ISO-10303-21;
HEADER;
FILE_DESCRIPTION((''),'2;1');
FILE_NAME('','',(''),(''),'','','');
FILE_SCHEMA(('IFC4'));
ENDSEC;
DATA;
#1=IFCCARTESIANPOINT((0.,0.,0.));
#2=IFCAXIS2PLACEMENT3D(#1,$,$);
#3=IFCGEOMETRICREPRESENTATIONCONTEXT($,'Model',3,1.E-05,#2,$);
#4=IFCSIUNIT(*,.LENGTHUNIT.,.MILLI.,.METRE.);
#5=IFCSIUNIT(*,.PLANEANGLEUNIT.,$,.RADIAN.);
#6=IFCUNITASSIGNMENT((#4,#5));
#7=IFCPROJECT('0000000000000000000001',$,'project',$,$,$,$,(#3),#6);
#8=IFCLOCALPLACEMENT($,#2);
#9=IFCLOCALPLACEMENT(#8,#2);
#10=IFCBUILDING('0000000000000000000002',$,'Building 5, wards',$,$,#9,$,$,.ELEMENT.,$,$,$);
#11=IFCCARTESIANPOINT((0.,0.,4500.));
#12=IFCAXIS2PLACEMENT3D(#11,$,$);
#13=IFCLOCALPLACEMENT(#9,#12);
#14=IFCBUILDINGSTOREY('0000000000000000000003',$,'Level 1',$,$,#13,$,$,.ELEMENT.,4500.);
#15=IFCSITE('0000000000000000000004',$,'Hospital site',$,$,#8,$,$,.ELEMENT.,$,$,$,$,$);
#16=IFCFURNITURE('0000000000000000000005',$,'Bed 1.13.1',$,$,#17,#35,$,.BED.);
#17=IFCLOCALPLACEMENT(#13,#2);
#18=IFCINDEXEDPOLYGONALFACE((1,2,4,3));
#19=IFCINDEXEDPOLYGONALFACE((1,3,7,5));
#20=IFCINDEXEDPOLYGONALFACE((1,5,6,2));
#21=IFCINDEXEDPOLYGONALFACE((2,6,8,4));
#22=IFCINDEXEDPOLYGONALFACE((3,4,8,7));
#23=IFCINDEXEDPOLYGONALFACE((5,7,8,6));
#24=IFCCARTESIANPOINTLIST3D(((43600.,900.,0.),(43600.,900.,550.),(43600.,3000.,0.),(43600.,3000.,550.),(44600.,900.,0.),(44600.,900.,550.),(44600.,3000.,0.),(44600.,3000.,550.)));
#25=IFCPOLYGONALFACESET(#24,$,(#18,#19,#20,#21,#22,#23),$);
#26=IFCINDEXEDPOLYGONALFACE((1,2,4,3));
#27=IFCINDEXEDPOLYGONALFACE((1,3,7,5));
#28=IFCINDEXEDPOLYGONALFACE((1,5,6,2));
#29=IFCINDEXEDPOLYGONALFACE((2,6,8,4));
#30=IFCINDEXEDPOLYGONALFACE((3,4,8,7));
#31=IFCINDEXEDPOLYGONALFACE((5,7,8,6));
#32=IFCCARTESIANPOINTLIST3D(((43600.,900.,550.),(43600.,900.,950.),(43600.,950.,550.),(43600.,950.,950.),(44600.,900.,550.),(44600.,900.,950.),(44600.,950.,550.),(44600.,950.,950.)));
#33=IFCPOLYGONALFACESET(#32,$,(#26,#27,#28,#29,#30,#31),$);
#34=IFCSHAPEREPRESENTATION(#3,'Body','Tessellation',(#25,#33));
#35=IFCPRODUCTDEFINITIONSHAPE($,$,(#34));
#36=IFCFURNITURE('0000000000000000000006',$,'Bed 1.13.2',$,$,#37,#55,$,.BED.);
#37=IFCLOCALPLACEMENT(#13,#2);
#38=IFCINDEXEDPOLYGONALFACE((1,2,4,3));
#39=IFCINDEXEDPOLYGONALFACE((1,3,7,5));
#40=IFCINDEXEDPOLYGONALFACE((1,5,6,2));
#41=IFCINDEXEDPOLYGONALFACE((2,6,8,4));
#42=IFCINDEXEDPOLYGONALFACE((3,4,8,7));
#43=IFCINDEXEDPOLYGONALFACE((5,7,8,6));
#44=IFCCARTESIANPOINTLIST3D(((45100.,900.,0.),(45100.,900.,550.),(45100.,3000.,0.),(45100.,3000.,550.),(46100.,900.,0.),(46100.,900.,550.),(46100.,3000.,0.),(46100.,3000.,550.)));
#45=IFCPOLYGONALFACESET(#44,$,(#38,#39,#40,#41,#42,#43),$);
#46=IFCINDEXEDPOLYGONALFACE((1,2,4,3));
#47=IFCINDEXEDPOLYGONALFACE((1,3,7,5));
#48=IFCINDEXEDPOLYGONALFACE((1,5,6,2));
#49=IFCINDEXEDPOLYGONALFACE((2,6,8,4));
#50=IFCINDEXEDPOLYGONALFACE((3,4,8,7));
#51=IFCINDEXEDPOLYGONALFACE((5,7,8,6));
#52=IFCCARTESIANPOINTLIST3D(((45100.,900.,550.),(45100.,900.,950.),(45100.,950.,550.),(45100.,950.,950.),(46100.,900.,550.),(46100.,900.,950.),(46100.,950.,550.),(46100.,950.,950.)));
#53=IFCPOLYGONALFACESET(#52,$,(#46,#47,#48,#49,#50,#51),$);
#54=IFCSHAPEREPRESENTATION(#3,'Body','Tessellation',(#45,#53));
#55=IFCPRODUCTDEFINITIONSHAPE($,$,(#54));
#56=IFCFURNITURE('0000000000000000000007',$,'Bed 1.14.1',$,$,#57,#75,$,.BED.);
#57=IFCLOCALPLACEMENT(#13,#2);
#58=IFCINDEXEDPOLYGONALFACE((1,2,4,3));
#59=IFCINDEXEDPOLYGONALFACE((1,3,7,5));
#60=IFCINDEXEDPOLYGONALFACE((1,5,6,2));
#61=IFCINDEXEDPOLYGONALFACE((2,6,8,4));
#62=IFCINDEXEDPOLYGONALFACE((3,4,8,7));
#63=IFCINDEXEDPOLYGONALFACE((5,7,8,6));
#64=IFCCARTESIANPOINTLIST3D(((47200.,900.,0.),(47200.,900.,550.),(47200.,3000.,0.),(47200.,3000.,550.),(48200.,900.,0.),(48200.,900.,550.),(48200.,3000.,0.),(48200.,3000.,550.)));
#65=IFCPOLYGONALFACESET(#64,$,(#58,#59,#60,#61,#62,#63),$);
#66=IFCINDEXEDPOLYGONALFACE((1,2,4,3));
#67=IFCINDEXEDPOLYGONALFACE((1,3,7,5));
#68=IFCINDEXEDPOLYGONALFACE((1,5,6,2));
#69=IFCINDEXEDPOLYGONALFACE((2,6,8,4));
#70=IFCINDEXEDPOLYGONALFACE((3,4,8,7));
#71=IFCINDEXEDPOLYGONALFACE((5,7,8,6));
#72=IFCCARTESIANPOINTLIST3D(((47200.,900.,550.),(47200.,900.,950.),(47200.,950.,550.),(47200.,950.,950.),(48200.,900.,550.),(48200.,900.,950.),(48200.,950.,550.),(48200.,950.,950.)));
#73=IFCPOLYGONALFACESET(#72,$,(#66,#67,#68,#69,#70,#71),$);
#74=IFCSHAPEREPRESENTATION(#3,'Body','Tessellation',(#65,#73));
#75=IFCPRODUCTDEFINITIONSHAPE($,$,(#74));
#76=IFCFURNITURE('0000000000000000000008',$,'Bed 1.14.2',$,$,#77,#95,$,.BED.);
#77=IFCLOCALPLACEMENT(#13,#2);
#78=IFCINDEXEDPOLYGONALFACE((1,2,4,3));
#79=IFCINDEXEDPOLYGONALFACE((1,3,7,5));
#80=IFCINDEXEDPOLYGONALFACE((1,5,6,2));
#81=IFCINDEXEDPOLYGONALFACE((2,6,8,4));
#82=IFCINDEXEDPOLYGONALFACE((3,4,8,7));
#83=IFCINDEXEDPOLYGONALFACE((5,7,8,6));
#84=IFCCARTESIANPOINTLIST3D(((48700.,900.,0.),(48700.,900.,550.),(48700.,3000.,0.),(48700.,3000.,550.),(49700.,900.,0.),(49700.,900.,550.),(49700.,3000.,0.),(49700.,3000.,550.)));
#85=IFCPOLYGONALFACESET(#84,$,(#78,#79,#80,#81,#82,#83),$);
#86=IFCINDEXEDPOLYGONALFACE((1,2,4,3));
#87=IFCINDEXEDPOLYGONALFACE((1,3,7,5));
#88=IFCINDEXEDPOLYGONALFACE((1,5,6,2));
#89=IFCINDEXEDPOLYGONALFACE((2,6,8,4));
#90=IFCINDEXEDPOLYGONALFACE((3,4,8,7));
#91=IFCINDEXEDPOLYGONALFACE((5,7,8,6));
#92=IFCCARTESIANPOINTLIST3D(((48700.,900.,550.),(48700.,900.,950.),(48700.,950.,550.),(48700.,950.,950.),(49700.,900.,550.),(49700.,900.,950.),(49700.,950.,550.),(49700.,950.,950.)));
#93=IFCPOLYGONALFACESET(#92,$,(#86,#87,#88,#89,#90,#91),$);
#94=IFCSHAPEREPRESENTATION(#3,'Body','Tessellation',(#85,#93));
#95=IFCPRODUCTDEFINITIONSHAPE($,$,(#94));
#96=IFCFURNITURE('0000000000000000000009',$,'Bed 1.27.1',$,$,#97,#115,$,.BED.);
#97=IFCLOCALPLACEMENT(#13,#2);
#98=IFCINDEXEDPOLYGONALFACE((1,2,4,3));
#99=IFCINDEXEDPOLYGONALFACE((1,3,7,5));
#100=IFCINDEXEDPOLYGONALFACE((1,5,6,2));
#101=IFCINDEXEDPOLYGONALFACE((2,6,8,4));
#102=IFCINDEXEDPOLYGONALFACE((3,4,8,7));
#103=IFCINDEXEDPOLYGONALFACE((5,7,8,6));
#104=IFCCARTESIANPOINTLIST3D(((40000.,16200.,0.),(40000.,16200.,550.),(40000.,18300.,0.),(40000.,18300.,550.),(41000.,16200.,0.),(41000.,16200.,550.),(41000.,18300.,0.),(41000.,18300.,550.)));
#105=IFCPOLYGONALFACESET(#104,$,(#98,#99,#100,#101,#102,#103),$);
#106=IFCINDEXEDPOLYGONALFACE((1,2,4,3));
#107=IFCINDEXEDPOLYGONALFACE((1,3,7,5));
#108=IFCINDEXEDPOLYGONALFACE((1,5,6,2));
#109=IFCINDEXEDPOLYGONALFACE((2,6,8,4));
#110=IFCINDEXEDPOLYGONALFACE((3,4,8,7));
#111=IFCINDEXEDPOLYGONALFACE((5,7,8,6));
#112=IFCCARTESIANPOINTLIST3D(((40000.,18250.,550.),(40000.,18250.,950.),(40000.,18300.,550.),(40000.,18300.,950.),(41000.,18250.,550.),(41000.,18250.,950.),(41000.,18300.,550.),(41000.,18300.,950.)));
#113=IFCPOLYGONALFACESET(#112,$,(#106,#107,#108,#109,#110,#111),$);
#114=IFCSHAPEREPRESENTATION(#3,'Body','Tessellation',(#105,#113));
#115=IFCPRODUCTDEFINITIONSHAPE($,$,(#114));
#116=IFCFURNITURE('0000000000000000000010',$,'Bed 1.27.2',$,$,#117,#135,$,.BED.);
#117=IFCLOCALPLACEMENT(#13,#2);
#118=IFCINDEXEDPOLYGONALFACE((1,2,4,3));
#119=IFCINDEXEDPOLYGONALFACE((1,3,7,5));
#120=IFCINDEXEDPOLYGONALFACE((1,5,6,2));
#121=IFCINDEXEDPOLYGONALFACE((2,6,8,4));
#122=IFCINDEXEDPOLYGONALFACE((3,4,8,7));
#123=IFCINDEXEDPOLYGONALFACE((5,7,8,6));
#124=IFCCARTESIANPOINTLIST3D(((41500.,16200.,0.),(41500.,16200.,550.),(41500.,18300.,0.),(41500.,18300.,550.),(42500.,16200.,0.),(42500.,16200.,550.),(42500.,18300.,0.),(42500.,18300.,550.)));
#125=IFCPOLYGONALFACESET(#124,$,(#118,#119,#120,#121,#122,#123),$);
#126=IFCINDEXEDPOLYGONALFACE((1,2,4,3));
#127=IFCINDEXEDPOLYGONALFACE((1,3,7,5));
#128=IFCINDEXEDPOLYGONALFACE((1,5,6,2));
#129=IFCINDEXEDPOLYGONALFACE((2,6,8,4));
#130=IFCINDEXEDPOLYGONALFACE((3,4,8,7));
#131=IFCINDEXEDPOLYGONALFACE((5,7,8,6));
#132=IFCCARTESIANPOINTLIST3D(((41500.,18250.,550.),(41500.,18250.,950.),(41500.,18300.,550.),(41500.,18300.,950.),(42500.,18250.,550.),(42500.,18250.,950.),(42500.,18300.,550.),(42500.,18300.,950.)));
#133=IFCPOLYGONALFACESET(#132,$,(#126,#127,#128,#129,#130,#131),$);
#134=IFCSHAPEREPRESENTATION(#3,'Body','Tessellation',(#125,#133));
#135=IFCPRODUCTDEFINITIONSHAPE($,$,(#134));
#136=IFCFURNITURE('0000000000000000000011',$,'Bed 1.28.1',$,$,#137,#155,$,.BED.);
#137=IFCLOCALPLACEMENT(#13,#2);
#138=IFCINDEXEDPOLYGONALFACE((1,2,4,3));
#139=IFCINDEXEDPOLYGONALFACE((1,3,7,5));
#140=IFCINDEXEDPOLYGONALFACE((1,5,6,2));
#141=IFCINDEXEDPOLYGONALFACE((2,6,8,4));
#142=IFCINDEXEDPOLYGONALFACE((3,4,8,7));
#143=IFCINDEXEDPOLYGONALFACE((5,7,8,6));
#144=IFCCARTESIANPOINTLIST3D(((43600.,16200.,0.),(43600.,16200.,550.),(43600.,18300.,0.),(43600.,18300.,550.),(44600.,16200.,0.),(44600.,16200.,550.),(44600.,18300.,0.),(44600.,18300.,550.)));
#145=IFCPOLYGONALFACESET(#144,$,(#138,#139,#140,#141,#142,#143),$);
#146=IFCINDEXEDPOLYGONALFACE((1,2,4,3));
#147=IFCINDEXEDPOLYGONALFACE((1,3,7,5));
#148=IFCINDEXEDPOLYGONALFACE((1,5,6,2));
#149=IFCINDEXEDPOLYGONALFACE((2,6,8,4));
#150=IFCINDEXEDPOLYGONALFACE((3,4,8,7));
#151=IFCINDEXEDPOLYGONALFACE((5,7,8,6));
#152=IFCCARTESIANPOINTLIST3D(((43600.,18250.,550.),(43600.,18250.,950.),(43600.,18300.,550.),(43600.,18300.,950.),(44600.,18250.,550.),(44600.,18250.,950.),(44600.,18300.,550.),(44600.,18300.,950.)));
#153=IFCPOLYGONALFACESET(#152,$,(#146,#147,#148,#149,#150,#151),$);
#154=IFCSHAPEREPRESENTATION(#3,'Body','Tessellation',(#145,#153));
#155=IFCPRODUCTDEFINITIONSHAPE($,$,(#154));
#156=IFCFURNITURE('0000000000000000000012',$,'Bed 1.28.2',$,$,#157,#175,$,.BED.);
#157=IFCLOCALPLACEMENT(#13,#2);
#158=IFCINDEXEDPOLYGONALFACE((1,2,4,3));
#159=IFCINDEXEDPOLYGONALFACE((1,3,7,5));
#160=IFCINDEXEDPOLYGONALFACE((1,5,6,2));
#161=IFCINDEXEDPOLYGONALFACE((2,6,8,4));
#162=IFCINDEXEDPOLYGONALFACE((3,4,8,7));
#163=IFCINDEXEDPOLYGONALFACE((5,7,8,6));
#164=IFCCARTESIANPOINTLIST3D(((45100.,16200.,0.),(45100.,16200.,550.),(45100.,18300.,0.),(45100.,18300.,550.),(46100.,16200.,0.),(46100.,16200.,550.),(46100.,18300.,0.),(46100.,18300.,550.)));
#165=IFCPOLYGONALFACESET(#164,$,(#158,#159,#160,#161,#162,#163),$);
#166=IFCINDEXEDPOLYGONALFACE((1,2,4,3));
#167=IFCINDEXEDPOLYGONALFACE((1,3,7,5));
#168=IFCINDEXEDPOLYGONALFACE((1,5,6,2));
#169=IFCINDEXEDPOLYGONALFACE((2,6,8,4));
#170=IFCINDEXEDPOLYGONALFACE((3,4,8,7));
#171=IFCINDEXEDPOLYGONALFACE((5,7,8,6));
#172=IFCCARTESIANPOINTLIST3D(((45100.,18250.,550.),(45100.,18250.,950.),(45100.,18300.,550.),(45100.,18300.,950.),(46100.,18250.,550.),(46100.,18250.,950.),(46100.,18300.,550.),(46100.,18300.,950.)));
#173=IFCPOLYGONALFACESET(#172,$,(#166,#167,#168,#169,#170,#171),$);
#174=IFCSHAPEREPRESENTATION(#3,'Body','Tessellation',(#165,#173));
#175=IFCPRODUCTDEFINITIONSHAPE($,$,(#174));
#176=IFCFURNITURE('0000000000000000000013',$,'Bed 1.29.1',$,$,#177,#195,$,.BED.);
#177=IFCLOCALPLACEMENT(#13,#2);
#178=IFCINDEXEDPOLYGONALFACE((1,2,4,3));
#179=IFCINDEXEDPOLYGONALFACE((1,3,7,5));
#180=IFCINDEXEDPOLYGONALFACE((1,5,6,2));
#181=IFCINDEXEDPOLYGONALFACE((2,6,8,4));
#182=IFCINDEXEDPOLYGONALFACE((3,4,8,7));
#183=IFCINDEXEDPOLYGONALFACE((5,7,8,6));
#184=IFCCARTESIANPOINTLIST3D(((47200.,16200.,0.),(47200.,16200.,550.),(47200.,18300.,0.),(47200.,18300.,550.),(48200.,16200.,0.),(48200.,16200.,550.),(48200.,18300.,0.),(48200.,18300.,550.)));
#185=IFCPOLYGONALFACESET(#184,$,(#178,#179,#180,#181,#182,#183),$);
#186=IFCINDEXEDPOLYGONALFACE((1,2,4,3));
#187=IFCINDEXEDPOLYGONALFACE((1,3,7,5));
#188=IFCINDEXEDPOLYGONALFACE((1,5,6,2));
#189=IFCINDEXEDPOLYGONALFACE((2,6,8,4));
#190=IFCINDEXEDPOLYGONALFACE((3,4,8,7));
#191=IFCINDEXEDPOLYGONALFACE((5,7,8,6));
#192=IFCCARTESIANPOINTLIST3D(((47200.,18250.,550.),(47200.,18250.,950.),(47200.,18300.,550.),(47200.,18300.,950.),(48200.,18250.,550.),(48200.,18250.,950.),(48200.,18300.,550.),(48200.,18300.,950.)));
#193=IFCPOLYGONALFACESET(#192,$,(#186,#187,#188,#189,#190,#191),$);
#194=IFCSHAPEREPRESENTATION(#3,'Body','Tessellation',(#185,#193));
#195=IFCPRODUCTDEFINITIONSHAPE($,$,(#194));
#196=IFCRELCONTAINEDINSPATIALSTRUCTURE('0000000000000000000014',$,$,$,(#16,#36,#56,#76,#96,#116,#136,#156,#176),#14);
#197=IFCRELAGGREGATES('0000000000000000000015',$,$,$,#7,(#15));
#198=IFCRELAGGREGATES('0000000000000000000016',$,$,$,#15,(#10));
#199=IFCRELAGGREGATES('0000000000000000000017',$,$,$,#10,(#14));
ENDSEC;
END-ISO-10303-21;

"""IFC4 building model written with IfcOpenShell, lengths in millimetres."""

from ifc_helpers import new_model, si_unit, frame, frame_2d, origin, place, context, project, spatial, rectangle, extrude, element, save


model = new_model("IFC4")

# Units and contexts
model_context = context("Model", 3, precision=1e-05, world=origin())
ifc_project = project(units=[si_unit("LENGTHUNIT", "METRE", prefix="MILLI"), si_unit("PLANEANGLEUNIT", "RADIAN")], contexts=[model_context])

# Site, building, storey
site_placement = place(None, origin())
site = spatial("IfcSite", under=ifc_project, at=site_placement, Name="Hospital site", CompositionType="ELEMENT")
building_placement = place(site_placement, origin())
building = spatial("IfcBuilding", under=site, at=building_placement, Name="Building 5, wards", CompositionType="ELEMENT")
storey_placement = place(building_placement, frame((0.0, 0.0, 4500.0)))
storey = spatial("IfcBuildingStorey", under=building, at=storey_placement, Name="Level 1", CompositionType="ELEMENT", Elevation=4500.0)

# Furniture
for number, where, name in (
    (1, (43600.0, 900.0, 0.0), "Bed 1.13.1"),
    (2, (45100.0, 900.0, 0.0), "Bed 1.13.2"),
    (3, (47200.0, 900.0, 0.0), "Bed 1.14.1"),
    (4, (48700.0, 900.0, 0.0), "Bed 1.14.2"),
):
    element("IfcFurniture", number, at=place(storey_placement, frame(where)), inside=storey, Name=name, PredefinedType="BED", context=model_context, shape_type="SweptSolid", body=[
        extrude(rectangle(XDim=1000.0, YDim=2100.0, at=frame_2d((500.0, 1050.0))), origin(), (0.0, 0.0, 1.0), 550.0),
        extrude(rectangle(XDim=1000.0, YDim=50.0, at=frame_2d((500.0, 25.0))), frame((0.0, 0.0, 550.0)), (0.0, 0.0, 1.0), 400.0),
    ])
for number, where, name in (
    (5, (40000.0, 16200.0, 0.0), "Bed 1.27.1"),
    (6, (41500.0, 16200.0, 0.0), "Bed 1.27.2"),
    (7, (43600.0, 16200.0, 0.0), "Bed 1.28.1"),
    (8, (45100.0, 16200.0, 0.0), "Bed 1.28.2"),
    (9, (47200.0, 16200.0, 0.0), "Bed 1.29.1"),
):
    element("IfcFurniture", number, at=place(storey_placement, frame(where)), inside=storey, Name=name, PredefinedType="BED", context=model_context, shape_type="SweptSolid", body=[
        extrude(rectangle(XDim=1000.0, YDim=2100.0, at=frame_2d((500.0, 1050.0))), origin(), (0.0, 0.0, 1.0), 550.0),
        extrude(rectangle(XDim=1000.0, YDim=50.0, at=frame_2d((500.0, 2075.0))), frame((0.0, 0.0, 550.0)), (0.0, 0.0, 1.0), 400.0),
    ])

save(model, "model.ifc")
